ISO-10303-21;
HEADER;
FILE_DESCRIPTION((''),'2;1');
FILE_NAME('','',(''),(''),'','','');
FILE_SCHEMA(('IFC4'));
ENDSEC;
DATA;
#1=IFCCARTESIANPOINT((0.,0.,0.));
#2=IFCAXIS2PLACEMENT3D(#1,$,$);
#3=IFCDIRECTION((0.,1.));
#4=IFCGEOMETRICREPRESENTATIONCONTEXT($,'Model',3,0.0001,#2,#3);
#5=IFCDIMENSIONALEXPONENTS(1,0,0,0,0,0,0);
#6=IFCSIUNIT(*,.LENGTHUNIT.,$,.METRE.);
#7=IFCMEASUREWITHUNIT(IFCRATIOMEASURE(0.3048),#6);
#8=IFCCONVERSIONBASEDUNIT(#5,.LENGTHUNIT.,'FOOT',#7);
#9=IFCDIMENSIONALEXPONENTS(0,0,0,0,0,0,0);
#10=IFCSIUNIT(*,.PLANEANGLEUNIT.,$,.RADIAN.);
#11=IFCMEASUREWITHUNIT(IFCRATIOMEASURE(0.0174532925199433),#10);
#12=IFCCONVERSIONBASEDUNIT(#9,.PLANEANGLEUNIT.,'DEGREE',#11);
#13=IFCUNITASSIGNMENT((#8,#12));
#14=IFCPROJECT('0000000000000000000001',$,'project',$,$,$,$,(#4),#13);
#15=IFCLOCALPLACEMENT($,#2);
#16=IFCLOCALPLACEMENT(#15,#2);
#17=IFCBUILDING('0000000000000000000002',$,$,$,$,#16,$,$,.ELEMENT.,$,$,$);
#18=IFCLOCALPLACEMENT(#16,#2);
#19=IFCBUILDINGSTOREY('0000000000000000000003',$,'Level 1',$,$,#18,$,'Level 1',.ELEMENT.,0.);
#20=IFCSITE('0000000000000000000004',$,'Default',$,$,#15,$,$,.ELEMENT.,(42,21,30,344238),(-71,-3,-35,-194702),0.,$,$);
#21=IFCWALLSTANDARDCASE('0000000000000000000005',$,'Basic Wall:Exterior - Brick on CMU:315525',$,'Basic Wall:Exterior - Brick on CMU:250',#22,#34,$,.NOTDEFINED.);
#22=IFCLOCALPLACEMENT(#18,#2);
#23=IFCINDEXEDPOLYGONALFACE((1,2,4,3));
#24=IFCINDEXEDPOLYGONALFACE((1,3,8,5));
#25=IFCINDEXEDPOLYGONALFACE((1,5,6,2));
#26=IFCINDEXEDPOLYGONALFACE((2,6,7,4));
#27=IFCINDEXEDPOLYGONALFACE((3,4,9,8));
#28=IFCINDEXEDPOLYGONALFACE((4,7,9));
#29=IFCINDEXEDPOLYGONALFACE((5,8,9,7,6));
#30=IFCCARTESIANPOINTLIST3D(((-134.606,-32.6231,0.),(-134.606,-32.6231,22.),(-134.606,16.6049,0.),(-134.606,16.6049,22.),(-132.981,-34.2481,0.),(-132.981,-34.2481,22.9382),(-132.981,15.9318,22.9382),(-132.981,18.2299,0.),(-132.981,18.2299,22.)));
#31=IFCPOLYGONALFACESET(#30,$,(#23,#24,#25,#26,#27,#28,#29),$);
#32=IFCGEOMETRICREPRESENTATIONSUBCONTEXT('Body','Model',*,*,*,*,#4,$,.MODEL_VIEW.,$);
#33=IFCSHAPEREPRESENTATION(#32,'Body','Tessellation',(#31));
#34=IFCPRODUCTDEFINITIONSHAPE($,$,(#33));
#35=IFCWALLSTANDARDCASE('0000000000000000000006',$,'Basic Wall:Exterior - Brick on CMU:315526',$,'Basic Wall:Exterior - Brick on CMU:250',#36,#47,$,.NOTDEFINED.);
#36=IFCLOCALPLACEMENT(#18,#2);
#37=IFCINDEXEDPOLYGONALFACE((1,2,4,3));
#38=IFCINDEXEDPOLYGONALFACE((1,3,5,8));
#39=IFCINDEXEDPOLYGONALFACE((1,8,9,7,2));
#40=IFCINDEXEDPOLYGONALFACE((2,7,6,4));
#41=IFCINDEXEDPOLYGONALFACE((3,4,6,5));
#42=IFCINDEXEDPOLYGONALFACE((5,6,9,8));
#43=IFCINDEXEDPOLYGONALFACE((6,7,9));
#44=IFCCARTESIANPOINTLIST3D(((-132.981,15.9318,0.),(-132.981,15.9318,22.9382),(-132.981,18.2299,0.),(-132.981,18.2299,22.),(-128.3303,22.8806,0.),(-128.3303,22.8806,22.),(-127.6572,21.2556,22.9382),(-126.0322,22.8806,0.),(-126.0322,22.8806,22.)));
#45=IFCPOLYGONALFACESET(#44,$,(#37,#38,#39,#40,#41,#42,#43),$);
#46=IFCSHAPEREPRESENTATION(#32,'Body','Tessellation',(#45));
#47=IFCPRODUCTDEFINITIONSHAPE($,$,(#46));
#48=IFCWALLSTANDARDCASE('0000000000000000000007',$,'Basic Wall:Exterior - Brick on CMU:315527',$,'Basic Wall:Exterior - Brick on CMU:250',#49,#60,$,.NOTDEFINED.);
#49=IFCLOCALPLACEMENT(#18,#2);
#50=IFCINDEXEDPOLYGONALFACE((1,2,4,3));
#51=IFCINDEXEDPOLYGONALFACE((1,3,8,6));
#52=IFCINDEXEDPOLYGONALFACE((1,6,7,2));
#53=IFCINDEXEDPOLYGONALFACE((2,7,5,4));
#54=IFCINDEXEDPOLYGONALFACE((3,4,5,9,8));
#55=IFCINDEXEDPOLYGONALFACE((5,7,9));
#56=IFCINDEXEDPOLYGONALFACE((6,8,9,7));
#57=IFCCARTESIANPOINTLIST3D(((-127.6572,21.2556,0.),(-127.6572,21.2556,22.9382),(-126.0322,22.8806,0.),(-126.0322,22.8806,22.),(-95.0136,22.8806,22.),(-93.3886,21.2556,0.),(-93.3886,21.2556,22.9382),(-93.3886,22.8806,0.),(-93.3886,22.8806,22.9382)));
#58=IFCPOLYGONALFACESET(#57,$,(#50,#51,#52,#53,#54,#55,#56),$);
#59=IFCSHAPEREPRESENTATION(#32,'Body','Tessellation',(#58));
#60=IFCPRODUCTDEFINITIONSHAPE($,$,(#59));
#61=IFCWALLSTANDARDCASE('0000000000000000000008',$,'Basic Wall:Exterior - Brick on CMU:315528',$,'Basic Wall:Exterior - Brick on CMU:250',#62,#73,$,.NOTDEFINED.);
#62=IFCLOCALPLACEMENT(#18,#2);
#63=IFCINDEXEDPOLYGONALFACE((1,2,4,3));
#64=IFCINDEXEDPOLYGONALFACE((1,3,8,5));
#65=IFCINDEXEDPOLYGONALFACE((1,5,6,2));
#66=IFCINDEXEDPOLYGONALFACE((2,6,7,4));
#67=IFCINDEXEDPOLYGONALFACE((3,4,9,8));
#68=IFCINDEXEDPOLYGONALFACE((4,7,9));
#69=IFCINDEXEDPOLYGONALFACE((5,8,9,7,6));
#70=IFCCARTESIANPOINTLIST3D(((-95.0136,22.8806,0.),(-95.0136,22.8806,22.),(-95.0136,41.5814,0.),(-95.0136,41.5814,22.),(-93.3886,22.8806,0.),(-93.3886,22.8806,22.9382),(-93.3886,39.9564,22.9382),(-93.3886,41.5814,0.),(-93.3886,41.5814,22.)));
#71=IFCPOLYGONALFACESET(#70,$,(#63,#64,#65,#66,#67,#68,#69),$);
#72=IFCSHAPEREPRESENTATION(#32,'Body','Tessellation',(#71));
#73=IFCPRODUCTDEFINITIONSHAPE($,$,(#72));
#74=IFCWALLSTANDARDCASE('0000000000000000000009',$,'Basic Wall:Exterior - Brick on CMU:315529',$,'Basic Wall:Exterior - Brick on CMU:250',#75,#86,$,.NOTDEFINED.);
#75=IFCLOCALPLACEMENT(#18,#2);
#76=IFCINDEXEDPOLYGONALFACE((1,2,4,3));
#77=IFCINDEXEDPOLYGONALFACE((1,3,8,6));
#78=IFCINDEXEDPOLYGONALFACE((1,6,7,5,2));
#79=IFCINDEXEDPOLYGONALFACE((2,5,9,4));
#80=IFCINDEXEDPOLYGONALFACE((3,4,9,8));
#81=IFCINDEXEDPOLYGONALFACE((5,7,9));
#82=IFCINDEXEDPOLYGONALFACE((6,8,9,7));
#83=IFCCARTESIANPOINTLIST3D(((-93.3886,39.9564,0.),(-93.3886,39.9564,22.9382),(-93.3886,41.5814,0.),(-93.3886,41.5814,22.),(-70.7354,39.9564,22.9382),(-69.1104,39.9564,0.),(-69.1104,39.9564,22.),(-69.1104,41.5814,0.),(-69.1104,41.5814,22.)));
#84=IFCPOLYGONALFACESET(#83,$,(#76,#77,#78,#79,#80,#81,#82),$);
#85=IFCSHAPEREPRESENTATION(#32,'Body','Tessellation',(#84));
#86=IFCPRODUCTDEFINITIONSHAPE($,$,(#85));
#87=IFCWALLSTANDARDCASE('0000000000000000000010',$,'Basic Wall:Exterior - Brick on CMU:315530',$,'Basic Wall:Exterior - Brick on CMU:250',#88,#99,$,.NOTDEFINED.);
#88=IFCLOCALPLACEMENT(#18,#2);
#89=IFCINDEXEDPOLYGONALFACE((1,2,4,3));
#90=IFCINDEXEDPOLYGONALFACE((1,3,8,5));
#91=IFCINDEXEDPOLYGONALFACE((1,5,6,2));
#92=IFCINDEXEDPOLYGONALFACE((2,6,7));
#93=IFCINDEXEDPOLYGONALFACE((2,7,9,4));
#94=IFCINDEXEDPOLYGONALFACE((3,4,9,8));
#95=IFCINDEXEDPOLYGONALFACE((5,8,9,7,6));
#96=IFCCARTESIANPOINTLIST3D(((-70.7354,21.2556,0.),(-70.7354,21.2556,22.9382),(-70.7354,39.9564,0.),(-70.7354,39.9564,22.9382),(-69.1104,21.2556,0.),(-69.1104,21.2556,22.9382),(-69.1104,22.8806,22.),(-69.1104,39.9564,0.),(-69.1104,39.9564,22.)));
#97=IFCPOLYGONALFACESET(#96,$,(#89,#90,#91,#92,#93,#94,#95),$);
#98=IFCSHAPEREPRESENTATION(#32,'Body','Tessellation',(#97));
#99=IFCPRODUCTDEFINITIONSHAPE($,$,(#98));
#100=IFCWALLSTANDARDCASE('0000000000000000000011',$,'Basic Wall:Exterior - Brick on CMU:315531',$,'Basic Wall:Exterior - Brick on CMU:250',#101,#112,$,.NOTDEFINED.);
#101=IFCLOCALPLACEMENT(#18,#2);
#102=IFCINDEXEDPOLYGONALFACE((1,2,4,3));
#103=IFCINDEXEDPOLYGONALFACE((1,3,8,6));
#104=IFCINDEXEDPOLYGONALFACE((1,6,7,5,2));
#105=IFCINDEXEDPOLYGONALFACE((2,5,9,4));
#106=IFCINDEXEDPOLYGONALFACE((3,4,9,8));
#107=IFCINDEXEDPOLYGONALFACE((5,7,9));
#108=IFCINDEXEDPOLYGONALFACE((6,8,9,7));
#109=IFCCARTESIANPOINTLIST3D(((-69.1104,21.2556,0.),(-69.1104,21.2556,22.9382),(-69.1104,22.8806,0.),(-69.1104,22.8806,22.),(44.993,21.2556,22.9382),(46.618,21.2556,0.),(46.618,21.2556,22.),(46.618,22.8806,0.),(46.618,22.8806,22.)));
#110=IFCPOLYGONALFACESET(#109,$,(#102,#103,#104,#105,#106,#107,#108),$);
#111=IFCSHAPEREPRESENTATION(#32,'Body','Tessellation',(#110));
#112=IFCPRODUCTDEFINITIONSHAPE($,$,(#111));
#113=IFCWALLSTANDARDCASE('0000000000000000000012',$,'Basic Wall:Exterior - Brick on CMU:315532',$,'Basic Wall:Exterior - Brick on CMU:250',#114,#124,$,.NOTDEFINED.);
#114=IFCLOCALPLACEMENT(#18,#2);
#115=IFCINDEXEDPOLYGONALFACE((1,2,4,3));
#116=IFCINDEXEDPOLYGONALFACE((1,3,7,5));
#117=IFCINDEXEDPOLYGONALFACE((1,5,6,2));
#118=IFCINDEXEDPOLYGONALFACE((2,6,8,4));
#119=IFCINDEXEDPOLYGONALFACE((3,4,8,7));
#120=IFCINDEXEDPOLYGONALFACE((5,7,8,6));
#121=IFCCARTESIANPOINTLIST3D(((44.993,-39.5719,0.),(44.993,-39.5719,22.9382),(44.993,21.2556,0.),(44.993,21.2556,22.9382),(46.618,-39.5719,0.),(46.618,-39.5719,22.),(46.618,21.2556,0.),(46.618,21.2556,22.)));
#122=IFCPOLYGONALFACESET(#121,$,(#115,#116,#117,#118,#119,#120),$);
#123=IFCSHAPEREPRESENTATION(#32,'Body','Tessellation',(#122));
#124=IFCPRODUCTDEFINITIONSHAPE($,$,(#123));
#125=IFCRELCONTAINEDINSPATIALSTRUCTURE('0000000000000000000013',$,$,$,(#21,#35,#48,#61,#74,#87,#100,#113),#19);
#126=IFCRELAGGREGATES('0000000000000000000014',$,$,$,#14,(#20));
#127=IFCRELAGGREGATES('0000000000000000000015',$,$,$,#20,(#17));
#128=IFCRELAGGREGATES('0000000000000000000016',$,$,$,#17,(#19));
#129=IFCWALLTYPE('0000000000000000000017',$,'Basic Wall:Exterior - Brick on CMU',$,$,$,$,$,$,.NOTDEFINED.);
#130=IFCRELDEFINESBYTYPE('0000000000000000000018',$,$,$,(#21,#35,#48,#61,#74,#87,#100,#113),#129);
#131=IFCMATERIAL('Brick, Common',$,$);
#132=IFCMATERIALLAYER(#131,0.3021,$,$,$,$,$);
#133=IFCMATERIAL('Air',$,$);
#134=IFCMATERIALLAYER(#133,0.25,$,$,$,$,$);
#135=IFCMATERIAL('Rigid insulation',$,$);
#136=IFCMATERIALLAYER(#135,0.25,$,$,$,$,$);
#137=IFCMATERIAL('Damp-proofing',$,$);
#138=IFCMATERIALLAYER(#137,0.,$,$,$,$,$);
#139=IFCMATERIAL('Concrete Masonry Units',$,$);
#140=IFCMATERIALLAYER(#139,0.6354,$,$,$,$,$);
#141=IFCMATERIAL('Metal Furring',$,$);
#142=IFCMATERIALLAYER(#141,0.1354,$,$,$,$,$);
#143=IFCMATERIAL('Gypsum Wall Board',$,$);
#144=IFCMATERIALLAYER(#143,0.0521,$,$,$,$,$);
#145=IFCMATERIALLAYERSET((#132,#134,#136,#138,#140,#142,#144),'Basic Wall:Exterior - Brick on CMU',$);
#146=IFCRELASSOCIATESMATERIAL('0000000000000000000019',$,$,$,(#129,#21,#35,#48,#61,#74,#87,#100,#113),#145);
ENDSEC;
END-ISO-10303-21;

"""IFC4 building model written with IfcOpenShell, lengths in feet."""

from ifc_helpers import new_model, entity, si_unit, converted_unit, direction, frame, frame_2d, origin, place, context, subcontext, project, spatial, polyline, rectangle, outline, extrude, clip, bounded_halfspace, material, layer, layer_set, layer_usage, type_object, element, save


model = new_model("IFC4")

# Units and contexts
model_context = context("Model", 3, precision=0.0001, world=origin(), true_north=direction((0.0, 1.0)))
body_context = subcontext(model_context, "Body", "Model", "MODEL_VIEW")
ifc_project = project(units=[converted_unit("LENGTHUNIT", "FOOT", entity("IfcRatioMeasure", 0.3048), si_unit("LENGTHUNIT", "METRE"), dimensions=[1, 0, 0, 0, 0, 0, 0]), converted_unit("PLANEANGLEUNIT", "DEGREE", entity("IfcRatioMeasure", 0.0174532925199433), si_unit("PLANEANGLEUNIT", "RADIAN"), dimensions=[0, 0, 0, 0, 0, 0, 0])], contexts=[model_context])

# Site, building, storey
site_placement = place(None, origin())
site = spatial("IfcSite", under=ifc_project, at=site_placement, Name="Default", CompositionType="ELEMENT", RefLatitude=(42, 21, 30, 344238), RefLongitude=(-71, -3, -35, -194702), RefElevation=0.0)
building_placement = place(site_placement, origin())
building = spatial("IfcBuilding", under=site, at=building_placement, CompositionType="ELEMENT")
storey_placement = place(building_placement, origin())
storey = spatial("IfcBuildingStorey", under=building, at=storey_placement, Name="Level 1", LongName="Level 1", CompositionType="ELEMENT", Elevation=0.0)

# Walls
ifc_material_1 = material(Name="Brick, Common")
ifc_layer_1 = layer(ifc_material_1, 0.3021)
ifc_material_2 = material(Name="Air")
ifc_layer_2 = layer(ifc_material_2, 0.25)
ifc_material_3 = material(Name="Rigid insulation")
ifc_layer_3 = layer(ifc_material_3, 0.25)
ifc_material_4 = material(Name="Damp-proofing")
ifc_layer_4 = layer(ifc_material_4, 0.0)
ifc_material_5 = material(Name="Concrete Masonry Units")
ifc_layer_5 = layer(ifc_material_5, 0.6354)
ifc_material_6 = material(Name="Metal Furring")
ifc_layer_6 = layer(ifc_material_6, 0.1354)
ifc_material_7 = material(Name="Gypsum Wall Board")
ifc_layer_7 = layer(ifc_material_7, 0.0521)
ifc_layer_set = layer_set([ifc_layer_1, ifc_layer_2, ifc_layer_3, ifc_layer_4, ifc_layer_5, ifc_layer_6, ifc_layer_7], Name="Basic Wall:Exterior - Brick on CMU")
wall_type = type_object("IfcWallType", Name="Basic Wall:Exterior - Brick on CMU", PredefinedType="NOTDEFINED", material=ifc_layer_set)
ifc_layer_usage_1 = layer_usage(ifc_layer_set, "AXIS2", "NEGATIVE", 0.8125)
wall_1_placement = place(storey_placement, frame((-133.7935, -34.2481, 0.0), z_axis=(0.0, 0.0, 1.0), x_axis=(0.0, 1.0, 0.0)))
element("IfcWallStandardCase", 1, at=wall_1_placement, inside=storey, type_object=wall_type, material=ifc_layer_usage_1, Name="Basic Wall:Exterior - Brick on CMU:315525", ObjectType="Basic Wall:Exterior - Brick on CMU:250", PredefinedType="NOTDEFINED", context=body_context, shape_type="Clipping", body=[
    clip(clip(extrude(outline(polyline([(52.478, -0.8125), (50.853, 0.8125), (1.625, 0.8125), (0.0, -0.8125), (50.1799, -0.8125), (52.478, -0.8125)])), origin(), (0.0, 0.0, 1.0), 22.9382), bounded_halfspace(frame((0.0, -0.8125, 22.9382), z_axis=(0.0, 0.5, 0.866025), x_axis=(-1.0, 0.0, 0.0)), False, frame((0.0, -0.8125, 22.9382)), polyline([(0.0, 0.0), (50.1799, 0.0), (50.853, 1.625), (1.625, 1.625), (0.0, 0.0)]))), bounded_halfspace(frame((50.1799, -0.8125, 22.9382), z_axis=(0.353553, 0.353553, 0.866025), x_axis=(-0.707107, 0.707107, 0.0)), False, frame((50.1799, -0.8125, 22.9382)), polyline([(0.0, 0.0), (2.2981, 0.0), (0.6731, 1.625), (0.0, 0.0)]))),
])
ifc_layer_usage_2 = layer_usage(ifc_layer_set, "AXIS2", "POSITIVE", -0.8125)
wall_2_placement = place(storey_placement, frame((-126.6067, 23.4552, 0.0), z_axis=(0.0, 0.0, 1.0), x_axis=(-0.707107, -0.707107, 0.0)))
element("IfcWallStandardCase", 2, at=wall_2_placement, inside=storey, type_object=wall_type, material=ifc_layer_usage_2, Name="Basic Wall:Exterior - Brick on CMU:315526", ObjectType="Basic Wall:Exterior - Brick on CMU:250", PredefinedType="NOTDEFINED", context=body_context, shape_type="Clipping", body=[
    clip(clip(extrude(outline(polyline([(8.2021, -0.8125), (9.8271, 0.8125), (2.2981, 0.8125), (0.0, 0.8125), (1.625, -0.8125), (8.2021, -0.8125)])), origin(), (0.0, 0.0, 1.0), 22.9382), bounded_halfspace(frame((2.2981, 0.8125, 22.9382), z_axis=(-0.353553, -0.353553, 0.866025), x_axis=(0.707107, -0.707107, 0.0)), False, frame((2.2981, 0.8125, 22.9382)), polyline([(0.0, 0.0), (-2.2981, 0.0), (-0.6731, -1.625), (0.0, 0.0)]))), bounded_halfspace(frame((1.625, -0.8125, 22.0), z_axis=(0.0, -0.5, 0.866025), x_axis=(1.0, 0.0, 0.0)), False, frame((1.625, -0.8125, 22.0)), polyline([(0.0, 0.0), (6.5771, 0.0), (8.2021, 1.625), (0.6731, 1.625), (0.0, 0.0)]))),
])
ifc_layer_usage_3 = layer_usage(ifc_layer_set, "AXIS2", "NEGATIVE", 0.8125)
wall_3_placement = place(storey_placement, frame((-127.6572, 22.0681, 0.0)))
element("IfcWallStandardCase", 3, at=wall_3_placement, inside=storey, type_object=wall_type, material=ifc_layer_usage_3, Name="Basic Wall:Exterior - Brick on CMU:315527", ObjectType="Basic Wall:Exterior - Brick on CMU:250", PredefinedType="NOTDEFINED", context=body_context, shape_type="Clipping", body=[
    clip(clip(extrude(outline(polyline([(34.2686, -0.8125), (34.2686, 0.8125), (32.6436, 0.8125), (1.625, 0.8125), (0.0, -0.8125), (34.2686, -0.8125)])), origin(), (0.0, 0.0, 1.0), 22.9382), bounded_halfspace(frame((0.0, -0.8125, 22.9382), z_axis=(0.0, 0.5, 0.866025), x_axis=(-1.0, 0.0, 0.0)), False, frame((0.0, -0.8125, 22.9382)), polyline([(0.0, 0.0), (34.2686, 0.0), (32.6436, 1.625), (1.625, 1.625), (0.0, 0.0)]))), bounded_halfspace(frame((34.2686, -0.8125, 22.9382), z_axis=(-0.5, 0.0, 0.866025), x_axis=(0.0, -1.0, 0.0)), False, frame((34.2686, -0.8125, 22.9382)), polyline([(0.0, 0.0), (0.0, 1.625), (-1.625, 1.625), (0.0, 0.0)]))),
])
ifc_layer_usage_4 = layer_usage(ifc_layer_set, "AXIS2", "NEGATIVE", 0.8125)
wall_4_placement = place(storey_placement, frame((-94.2011, 22.8806, 0.0), z_axis=(0.0, 0.0, 1.0), x_axis=(0.0, 1.0, 0.0)))
element("IfcWallStandardCase", 4, at=wall_4_placement, inside=storey, type_object=wall_type, material=ifc_layer_usage_4, Name="Basic Wall:Exterior - Brick on CMU:315528", ObjectType="Basic Wall:Exterior - Brick on CMU:250", PredefinedType="NOTDEFINED", context=body_context, shape_type="Clipping", body=[
    clip(clip(extrude(rectangle(XDim=18.7008, YDim=1.625, at=frame_2d((9.3504, 0.0), x_axis=(-1.0, 0.0))), origin(), (0.0, 0.0, 1.0), 22.9382), bounded_halfspace(frame((17.0758, -0.8125, 22.9382), z_axis=(0.5, 0.0, 0.866025), x_axis=(0.0, 1.0, 0.0)), False, frame((17.0758, -0.8125, 22.9382)), polyline([(0.0, 0.0), (1.625, 0.0), (1.625, 1.625), (0.0, 0.0)]))), bounded_halfspace(frame((0.0, -0.8125, 22.9382), z_axis=(0.0, 0.5, 0.866025), x_axis=(-1.0, 0.0, 0.0)), False, frame((0.0, -0.8125, 22.9382)), polyline([(0.0, 0.0), (17.0758, 0.0), (18.7008, 1.625), (0.0, 1.625), (0.0, 0.0)]))),
])
ifc_layer_usage_5 = layer_usage(ifc_layer_set, "AXIS2", "NEGATIVE", 0.8125)
wall_5_placement = place(storey_placement, frame((-93.3886, 40.7689, 0.0)))
element("IfcWallStandardCase", 5, at=wall_5_placement, inside=storey, type_object=wall_type, material=ifc_layer_usage_5, Name="Basic Wall:Exterior - Brick on CMU:315529", ObjectType="Basic Wall:Exterior - Brick on CMU:250", PredefinedType="NOTDEFINED", context=body_context, shape_type="Clipping", body=[
    clip(clip(extrude(rectangle(XDim=24.2782, YDim=1.625, at=frame_2d((12.1391, 0.0), x_axis=(-1.0, 0.0))), origin(), (0.0, 0.0, 1.0), 22.9382), bounded_halfspace(frame((0.0, -0.8125, 22.9382), z_axis=(0.0, 0.5, 0.866025), x_axis=(-1.0, 0.0, 0.0)), False, frame((0.0, -0.8125, 22.9382)), polyline([(0.0, 0.0), (22.6532, 0.0), (24.2782, 1.625), (0.0, 1.625), (0.0, 0.0)]))), bounded_halfspace(frame((22.6532, -0.8125, 22.9382), z_axis=(0.5, 0.0, 0.866025), x_axis=(0.0, 1.0, 0.0)), False, frame((22.6532, -0.8125, 22.9382)), polyline([(0.0, 0.0), (1.625, 0.0), (1.625, 1.625), (0.0, 0.0)]))),
])
ifc_layer_usage_6 = layer_usage(ifc_layer_set, "AXIS2", "NEGATIVE", 0.8125)
wall_6_placement = place(storey_placement, frame((-69.9229, 39.9564, 0.0), z_axis=(0.0, 0.0, 1.0), x_axis=(0.0, -1.0, 0.0)))
element("IfcWallStandardCase", 6, at=wall_6_placement, inside=storey, type_object=wall_type, material=ifc_layer_usage_6, Name="Basic Wall:Exterior - Brick on CMU:315530", ObjectType="Basic Wall:Exterior - Brick on CMU:250", PredefinedType="NOTDEFINED", context=body_context, shape_type="Clipping", body=[
    clip(clip(extrude(rectangle(XDim=18.7008, YDim=1.625, at=frame_2d((9.3504, 0.0), x_axis=(-1.0, 0.0))), origin(), (0.0, 0.0, 1.0), 22.9382), bounded_halfspace(frame((18.7008, -0.8125, 22.9382), z_axis=(-0.5, 0.0, 0.866025), x_axis=(0.0, -1.0, 0.0)), False, frame((18.7008, -0.8125, 22.9382)), polyline([(0.0, 0.0), (0.0, 1.625), (-1.625, 1.625), (0.0, 0.0)]))), bounded_halfspace(frame((0.0, -0.8125, 22.9382), z_axis=(0.0, 0.5, 0.866025), x_axis=(-1.0, 0.0, 0.0)), False, frame((0.0, -0.8125, 22.9382)), polyline([(0.0, 0.0), (18.7008, 0.0), (17.0758, 1.625), (0.0, 1.625), (0.0, 0.0)]))),
])
ifc_layer_usage_7 = layer_usage(ifc_layer_set, "AXIS2", "NEGATIVE", 0.8125)
wall_7_placement = place(storey_placement, frame((-69.1104, 22.0681, 0.0)))
element("IfcWallStandardCase", 7, at=wall_7_placement, inside=storey, type_object=wall_type, material=ifc_layer_usage_7, Name="Basic Wall:Exterior - Brick on CMU:315531", ObjectType="Basic Wall:Exterior - Brick on CMU:250", PredefinedType="NOTDEFINED", context=body_context, shape_type="Clipping", body=[
    clip(clip(extrude(rectangle(XDim=115.7284, YDim=1.625, at=frame_2d((57.8642, 0.0), x_axis=(-1.0, 0.0))), origin(), (0.0, 0.0, 1.0), 22.9382), bounded_halfspace(frame((114.1034, -0.8125, 22.9382), z_axis=(0.5, 0.0, 0.866025), x_axis=(0.0, 1.0, 0.0)), False, frame((114.1034, -0.8125, 22.9382)), polyline([(0.0, 0.0), (1.625, 0.0), (1.625, 1.625), (0.0, 0.0)]))), bounded_halfspace(frame((0.0, -0.8125, 22.9382), z_axis=(0.0, 0.5, 0.866025), x_axis=(-1.0, 0.0, 0.0)), False, frame((0.0, -0.8125, 22.9382)), polyline([(0.0, 0.0), (114.1034, 0.0), (115.7284, 1.625), (0.0, 1.625), (0.0, 0.0)]))),
])
ifc_layer_usage_8 = layer_usage(ifc_layer_set, "AXIS2", "NEGATIVE", 0.8125)
wall_8_placement = place(storey_placement, frame((45.8055, 21.2556, 0.0), z_axis=(0.0, 0.0, 1.0), x_axis=(0.0, -1.0, 0.0)))
element("IfcWallStandardCase", 8, at=wall_8_placement, inside=storey, type_object=wall_type, material=ifc_layer_usage_8, Name="Basic Wall:Exterior - Brick on CMU:315532", ObjectType="Basic Wall:Exterior - Brick on CMU:250", PredefinedType="NOTDEFINED", context=body_context, shape_type="Clipping", body=[
    clip(extrude(rectangle(XDim=60.8275, YDim=1.625, at=frame_2d((30.4138, 0.0), x_axis=(-1.0, 0.0))), origin(), (0.0, 0.0, 1.0), 22.9382), bounded_halfspace(frame((0.0, -0.8125, 22.9382), z_axis=(0.0, 0.5, 0.866025), x_axis=(-1.0, 0.0, 0.0)), False, frame((0.0, -0.8125, 22.9382)), polyline([(0.0, 0.0), (60.8275, 0.0), (60.8275, 1.625), (0.0, 1.625), (0.0, 0.0)]))),
])

save(model, "model.ifc")
